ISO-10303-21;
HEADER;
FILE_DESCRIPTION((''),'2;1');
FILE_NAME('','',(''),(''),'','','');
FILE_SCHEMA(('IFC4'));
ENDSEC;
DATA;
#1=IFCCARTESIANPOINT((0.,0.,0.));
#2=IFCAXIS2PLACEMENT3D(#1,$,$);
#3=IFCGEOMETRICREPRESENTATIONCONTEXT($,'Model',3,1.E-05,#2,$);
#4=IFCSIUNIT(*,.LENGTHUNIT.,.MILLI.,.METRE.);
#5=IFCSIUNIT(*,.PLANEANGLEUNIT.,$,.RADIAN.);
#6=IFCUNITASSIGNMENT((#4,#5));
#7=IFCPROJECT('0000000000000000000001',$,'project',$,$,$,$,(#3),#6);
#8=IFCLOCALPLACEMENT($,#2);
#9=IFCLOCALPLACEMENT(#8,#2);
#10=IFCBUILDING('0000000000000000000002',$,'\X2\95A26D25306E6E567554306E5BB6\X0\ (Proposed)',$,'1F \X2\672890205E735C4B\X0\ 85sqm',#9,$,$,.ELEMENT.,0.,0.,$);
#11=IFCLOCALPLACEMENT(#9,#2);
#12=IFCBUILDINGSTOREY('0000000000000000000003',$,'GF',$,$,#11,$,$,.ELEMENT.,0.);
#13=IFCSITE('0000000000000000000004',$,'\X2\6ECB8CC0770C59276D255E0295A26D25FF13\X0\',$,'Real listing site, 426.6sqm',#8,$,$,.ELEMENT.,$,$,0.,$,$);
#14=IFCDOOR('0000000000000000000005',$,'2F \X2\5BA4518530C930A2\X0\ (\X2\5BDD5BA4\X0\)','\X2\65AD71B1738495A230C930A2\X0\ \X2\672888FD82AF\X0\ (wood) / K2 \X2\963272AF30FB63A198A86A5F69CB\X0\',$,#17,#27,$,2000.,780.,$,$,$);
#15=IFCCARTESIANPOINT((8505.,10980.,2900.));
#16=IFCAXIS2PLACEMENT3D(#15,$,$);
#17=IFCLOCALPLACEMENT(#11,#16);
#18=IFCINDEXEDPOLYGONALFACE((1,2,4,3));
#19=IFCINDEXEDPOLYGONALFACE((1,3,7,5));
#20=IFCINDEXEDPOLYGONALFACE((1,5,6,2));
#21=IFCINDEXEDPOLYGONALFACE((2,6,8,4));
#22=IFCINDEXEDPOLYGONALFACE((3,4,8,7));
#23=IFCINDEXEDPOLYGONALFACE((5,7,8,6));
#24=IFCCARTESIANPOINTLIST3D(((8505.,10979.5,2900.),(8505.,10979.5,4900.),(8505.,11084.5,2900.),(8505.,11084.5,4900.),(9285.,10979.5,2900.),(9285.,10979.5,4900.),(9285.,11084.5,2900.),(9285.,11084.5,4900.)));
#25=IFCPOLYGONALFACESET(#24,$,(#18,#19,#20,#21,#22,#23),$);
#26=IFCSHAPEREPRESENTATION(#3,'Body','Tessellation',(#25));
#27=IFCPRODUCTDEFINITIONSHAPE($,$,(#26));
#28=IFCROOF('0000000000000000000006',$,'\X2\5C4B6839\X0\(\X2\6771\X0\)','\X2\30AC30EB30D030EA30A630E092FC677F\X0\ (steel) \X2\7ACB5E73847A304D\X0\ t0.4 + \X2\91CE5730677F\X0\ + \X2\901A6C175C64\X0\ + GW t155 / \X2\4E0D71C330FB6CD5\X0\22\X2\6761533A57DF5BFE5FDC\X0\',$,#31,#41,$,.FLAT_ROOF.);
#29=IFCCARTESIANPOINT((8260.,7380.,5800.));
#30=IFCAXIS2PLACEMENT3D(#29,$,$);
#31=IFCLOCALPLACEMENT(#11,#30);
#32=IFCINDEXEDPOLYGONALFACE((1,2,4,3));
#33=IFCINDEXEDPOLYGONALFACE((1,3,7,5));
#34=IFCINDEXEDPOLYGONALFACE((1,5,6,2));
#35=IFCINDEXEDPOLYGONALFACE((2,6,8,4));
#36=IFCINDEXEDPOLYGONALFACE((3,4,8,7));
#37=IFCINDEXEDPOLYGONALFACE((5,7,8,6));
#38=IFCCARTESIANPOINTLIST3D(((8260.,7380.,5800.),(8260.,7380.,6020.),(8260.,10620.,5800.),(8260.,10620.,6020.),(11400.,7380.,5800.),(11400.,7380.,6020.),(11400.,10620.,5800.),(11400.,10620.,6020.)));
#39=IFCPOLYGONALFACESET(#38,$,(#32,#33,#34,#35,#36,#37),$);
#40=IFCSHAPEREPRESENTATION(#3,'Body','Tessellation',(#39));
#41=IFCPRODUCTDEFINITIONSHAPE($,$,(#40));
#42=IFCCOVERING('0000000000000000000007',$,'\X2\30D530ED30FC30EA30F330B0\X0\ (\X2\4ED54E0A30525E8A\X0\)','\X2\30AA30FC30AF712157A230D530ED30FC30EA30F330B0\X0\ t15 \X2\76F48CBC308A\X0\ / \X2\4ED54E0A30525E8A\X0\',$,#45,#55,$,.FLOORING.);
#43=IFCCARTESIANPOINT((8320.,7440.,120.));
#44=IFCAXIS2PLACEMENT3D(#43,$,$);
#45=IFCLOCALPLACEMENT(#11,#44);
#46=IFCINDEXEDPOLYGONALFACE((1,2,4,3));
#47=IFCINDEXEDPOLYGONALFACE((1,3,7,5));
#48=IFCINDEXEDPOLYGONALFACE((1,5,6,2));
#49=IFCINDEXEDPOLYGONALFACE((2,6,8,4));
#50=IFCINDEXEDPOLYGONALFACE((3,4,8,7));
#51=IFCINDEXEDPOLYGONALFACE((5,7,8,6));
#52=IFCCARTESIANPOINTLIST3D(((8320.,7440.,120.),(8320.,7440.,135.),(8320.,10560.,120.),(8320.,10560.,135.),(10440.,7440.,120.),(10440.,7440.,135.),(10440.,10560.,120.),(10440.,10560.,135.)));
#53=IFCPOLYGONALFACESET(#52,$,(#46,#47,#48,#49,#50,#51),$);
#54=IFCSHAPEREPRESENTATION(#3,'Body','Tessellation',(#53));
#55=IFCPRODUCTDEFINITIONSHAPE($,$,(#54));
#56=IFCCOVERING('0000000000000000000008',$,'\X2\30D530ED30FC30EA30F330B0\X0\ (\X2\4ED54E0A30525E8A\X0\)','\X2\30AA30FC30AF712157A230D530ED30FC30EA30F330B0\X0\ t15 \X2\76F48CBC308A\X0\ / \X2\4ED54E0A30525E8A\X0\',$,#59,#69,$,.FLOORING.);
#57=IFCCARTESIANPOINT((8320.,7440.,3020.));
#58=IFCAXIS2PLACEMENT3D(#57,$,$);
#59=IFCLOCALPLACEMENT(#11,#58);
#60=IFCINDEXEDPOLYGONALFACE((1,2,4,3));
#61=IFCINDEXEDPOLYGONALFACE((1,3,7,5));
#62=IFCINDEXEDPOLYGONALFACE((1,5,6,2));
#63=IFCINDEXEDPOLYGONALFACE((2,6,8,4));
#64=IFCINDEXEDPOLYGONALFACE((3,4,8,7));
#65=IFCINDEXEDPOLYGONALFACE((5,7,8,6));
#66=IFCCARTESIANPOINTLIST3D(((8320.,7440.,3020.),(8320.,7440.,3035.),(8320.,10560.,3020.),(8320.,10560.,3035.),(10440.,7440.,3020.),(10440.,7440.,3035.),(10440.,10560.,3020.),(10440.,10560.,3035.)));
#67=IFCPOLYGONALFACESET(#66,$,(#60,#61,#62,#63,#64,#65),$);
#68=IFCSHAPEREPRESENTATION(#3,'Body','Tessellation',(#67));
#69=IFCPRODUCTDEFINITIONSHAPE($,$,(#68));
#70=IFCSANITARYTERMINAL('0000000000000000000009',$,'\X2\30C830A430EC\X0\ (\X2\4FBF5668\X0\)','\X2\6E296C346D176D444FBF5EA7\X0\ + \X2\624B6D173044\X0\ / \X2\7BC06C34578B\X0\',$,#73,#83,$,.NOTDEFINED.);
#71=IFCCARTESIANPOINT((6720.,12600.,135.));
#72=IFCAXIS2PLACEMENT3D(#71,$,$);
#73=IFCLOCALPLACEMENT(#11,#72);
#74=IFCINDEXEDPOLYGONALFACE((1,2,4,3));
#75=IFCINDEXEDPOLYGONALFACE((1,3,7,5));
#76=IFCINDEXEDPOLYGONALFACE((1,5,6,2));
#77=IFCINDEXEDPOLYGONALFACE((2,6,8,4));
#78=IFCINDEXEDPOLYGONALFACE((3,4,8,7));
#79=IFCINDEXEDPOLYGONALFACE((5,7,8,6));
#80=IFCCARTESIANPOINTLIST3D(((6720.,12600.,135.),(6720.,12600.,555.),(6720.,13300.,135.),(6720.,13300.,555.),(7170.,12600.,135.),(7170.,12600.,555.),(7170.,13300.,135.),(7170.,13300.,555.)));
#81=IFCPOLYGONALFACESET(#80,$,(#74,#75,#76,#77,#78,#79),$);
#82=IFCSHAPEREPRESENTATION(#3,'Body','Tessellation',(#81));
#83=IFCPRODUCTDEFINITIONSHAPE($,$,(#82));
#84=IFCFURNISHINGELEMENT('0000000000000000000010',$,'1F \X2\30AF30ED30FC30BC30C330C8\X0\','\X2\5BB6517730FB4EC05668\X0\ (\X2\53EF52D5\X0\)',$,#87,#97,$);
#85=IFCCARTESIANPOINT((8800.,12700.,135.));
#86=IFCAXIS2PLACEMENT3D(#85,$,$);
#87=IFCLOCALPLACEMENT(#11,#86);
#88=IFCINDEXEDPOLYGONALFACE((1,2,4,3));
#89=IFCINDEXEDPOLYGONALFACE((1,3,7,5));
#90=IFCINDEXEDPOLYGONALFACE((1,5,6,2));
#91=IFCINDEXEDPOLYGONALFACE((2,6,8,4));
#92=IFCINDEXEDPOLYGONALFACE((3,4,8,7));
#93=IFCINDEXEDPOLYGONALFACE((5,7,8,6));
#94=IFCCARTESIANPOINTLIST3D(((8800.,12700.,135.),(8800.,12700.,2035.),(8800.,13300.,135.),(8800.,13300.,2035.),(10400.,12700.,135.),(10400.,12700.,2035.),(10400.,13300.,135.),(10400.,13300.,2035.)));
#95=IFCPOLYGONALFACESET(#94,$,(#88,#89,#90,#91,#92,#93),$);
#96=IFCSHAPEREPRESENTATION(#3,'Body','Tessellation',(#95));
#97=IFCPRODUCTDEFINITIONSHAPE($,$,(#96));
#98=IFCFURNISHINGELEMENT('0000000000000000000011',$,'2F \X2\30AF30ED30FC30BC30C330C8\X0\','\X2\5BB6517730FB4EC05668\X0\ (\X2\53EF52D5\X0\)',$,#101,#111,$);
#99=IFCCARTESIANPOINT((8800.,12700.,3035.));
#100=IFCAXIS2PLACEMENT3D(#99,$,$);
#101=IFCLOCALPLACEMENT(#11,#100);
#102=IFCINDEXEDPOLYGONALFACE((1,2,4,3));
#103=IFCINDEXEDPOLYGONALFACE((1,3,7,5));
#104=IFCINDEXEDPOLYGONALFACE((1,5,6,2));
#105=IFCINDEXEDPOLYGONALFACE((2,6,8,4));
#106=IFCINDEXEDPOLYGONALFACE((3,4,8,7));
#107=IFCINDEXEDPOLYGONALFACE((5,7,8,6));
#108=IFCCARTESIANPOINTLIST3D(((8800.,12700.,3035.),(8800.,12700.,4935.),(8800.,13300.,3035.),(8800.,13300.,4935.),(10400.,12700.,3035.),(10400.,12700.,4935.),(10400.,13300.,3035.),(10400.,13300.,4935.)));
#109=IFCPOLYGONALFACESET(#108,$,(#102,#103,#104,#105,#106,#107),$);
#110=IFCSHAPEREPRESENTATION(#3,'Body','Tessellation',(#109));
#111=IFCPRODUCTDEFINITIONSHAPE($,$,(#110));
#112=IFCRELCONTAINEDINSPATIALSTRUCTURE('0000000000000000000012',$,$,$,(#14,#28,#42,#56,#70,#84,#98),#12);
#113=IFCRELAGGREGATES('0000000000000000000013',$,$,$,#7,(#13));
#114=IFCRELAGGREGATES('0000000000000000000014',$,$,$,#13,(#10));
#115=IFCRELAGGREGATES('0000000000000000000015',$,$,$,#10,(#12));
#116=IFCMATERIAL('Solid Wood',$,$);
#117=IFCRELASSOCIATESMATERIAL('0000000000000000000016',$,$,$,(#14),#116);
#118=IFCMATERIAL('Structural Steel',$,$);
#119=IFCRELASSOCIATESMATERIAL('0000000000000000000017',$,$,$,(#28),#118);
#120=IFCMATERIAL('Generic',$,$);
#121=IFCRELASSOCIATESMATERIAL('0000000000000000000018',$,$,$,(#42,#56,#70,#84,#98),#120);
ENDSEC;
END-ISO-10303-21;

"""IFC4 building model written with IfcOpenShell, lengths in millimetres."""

from ifc_helpers import new_model, si_unit, frame, frame_2d, origin, place, context, project, spatial, rectangle, extrude, material, element, save


model = new_model("IFC4")

# Units and contexts
model_context = context("Model", 3, precision=1e-05, world=origin())
ifc_project = project(units=[si_unit("LENGTHUNIT", "METRE", prefix="MILLI"), si_unit("PLANEANGLEUNIT", "RADIAN")], contexts=[model_context])

# Site, building, storey
site_placement = place(None, origin())
site = spatial("IfcSite", under=ifc_project, at=site_placement, Name="滋賀県大津市関津３", ObjectType="Real listing site, 426.6sqm", CompositionType="ELEMENT", RefElevation=0.0)
building_placement = place(site_placement, origin())
building = spatial("IfcBuilding", under=site, at=building_placement, Name="関津の湖畔の家 (Proposed)", ObjectType="1F 木造平屋 85sqm", CompositionType="ELEMENT", ElevationOfRefHeight=0.0, ElevationOfTerrain=0.0)
storey_placement = place(building_placement, origin())
storey = spatial("IfcBuildingStorey", under=building, at=storey_placement, Name="GF", CompositionType="ELEMENT", Elevation=0.0)

# Shared definitions
ifc_material_1 = material(Name="Solid Wood")

# Door
door_1_placement = place(storey_placement, frame((8505.0, 10980.0, 2900.0)))
element("IfcDoor", 1, at=door_1_placement, inside=storey, material=ifc_material_1, Name="2F 室内ドア (寝室)", Description="断熱玄関ドア 木製芯 (wood) / K2 防犯・採風機構", OverallHeight=2000.0, OverallWidth=780.0, context=model_context, shape_type="SweptSolid", body=[
    extrude(rectangle(XDim=780.0, YDim=105.0, at=frame_2d((390.0, 52.0))), frame((8505.0, 10980.0, 2900.0)), (0.0, 0.0, 1.0), 2000.0),
])

# Roof
ifc_material_2 = material(Name="Structural Steel")
roof_placement = place(storey_placement, frame((8260.0, 7380.0, 5800.0)))
element("IfcRoof", 2, at=roof_placement, inside=storey, material=ifc_material_2, Name="屋根(東)", Description="ガルバリウム鋼板 (steel) 立平葺き t0.4 + 野地板 + 通気層 + GW t155 / 不燃・法22条区域対応", PredefinedType="FLAT_ROOF", context=model_context, shape_type="SweptSolid", body=[
    extrude(rectangle(XDim=3140.0, YDim=3240.0, at=frame_2d((1570.0, 1620.0))), frame((8260.0, 7380.0, 5800.0)), (0.0, 0.0, 1.0), 220.0),
])

# Coverings
ifc_material_3 = material(Name="Generic")
covering_1_placement = place(storey_placement, frame((8320.0, 7440.0, 120.0)))
element("IfcCovering", 3, at=covering_1_placement, inside=storey, material=ifc_material_3, Name="フローリング (仕上げ床)", Description="オーク無垢フローリング t15 直貼り / 仕上げ床", PredefinedType="FLOORING", context=model_context, shape_type="SweptSolid", body=[
    extrude(rectangle(XDim=2120.0, YDim=3120.0, at=frame_2d((1060.0, 1560.0))), frame((8320.0, 7440.0, 120.0)), (0.0, 0.0, 1.0), 15.0),
])
covering_2_placement = place(storey_placement, frame((8320.0, 7440.0, 3020.0)))
element("IfcCovering", 4, at=covering_2_placement, inside=storey, material=ifc_material_3, Name="フローリング (仕上げ床)", Description="オーク無垢フローリング t15 直貼り / 仕上げ床", PredefinedType="FLOORING", context=model_context, shape_type="SweptSolid", body=[
    extrude(rectangle(XDim=2120.0, YDim=3120.0, at=frame_2d((1060.0, 1560.0))), frame((8320.0, 7440.0, 3020.0)), (0.0, 0.0, 1.0), 15.0),
])

# Sanitary terminal
sanitary_terminal_placement = place(storey_placement, frame((6720.0, 12600.0, 135.0)))
element("IfcSanitaryTerminal", 5, at=sanitary_terminal_placement, inside=storey, material=ifc_material_3, Name="トイレ (便器)", Description="温水洗浄便座 + 手洗い / 節水型", PredefinedType="NOTDEFINED", context=model_context, shape_type="SweptSolid", body=[
    extrude(rectangle(XDim=450.0, YDim=700.0, at=frame_2d((225.0, 350.0))), frame((6720.0, 12600.0, 135.0)), (0.0, 0.0, 1.0), 420.0),
])

# Furnishing elements
furnishing_1_placement = place(storey_placement, frame((8800.0, 12700.0, 135.0)))
element("IfcFurnishingElement", 6, at=furnishing_1_placement, inside=storey, material=ifc_material_3, Name="1F クローゼット", Description="家具・什器 (可動)", context=model_context, shape_type="SweptSolid", body=[
    extrude(rectangle(XDim=1600.0, YDim=600.0, at=frame_2d((800.0, 300.0))), frame((8800.0, 12700.0, 135.0)), (0.0, 0.0, 1.0), 1900.0),
])
furnishing_2_placement = place(storey_placement, frame((8800.0, 12700.0, 3035.0)))
element("IfcFurnishingElement", 7, at=furnishing_2_placement, inside=storey, material=ifc_material_3, Name="2F クローゼット", Description="家具・什器 (可動)", context=model_context, shape_type="SweptSolid", body=[
    extrude(rectangle(XDim=1600.0, YDim=600.0, at=frame_2d((800.0, 300.0))), frame((8800.0, 12700.0, 3035.0)), (0.0, 0.0, 1.0), 1900.0),
])

save(model, "model.ifc")
